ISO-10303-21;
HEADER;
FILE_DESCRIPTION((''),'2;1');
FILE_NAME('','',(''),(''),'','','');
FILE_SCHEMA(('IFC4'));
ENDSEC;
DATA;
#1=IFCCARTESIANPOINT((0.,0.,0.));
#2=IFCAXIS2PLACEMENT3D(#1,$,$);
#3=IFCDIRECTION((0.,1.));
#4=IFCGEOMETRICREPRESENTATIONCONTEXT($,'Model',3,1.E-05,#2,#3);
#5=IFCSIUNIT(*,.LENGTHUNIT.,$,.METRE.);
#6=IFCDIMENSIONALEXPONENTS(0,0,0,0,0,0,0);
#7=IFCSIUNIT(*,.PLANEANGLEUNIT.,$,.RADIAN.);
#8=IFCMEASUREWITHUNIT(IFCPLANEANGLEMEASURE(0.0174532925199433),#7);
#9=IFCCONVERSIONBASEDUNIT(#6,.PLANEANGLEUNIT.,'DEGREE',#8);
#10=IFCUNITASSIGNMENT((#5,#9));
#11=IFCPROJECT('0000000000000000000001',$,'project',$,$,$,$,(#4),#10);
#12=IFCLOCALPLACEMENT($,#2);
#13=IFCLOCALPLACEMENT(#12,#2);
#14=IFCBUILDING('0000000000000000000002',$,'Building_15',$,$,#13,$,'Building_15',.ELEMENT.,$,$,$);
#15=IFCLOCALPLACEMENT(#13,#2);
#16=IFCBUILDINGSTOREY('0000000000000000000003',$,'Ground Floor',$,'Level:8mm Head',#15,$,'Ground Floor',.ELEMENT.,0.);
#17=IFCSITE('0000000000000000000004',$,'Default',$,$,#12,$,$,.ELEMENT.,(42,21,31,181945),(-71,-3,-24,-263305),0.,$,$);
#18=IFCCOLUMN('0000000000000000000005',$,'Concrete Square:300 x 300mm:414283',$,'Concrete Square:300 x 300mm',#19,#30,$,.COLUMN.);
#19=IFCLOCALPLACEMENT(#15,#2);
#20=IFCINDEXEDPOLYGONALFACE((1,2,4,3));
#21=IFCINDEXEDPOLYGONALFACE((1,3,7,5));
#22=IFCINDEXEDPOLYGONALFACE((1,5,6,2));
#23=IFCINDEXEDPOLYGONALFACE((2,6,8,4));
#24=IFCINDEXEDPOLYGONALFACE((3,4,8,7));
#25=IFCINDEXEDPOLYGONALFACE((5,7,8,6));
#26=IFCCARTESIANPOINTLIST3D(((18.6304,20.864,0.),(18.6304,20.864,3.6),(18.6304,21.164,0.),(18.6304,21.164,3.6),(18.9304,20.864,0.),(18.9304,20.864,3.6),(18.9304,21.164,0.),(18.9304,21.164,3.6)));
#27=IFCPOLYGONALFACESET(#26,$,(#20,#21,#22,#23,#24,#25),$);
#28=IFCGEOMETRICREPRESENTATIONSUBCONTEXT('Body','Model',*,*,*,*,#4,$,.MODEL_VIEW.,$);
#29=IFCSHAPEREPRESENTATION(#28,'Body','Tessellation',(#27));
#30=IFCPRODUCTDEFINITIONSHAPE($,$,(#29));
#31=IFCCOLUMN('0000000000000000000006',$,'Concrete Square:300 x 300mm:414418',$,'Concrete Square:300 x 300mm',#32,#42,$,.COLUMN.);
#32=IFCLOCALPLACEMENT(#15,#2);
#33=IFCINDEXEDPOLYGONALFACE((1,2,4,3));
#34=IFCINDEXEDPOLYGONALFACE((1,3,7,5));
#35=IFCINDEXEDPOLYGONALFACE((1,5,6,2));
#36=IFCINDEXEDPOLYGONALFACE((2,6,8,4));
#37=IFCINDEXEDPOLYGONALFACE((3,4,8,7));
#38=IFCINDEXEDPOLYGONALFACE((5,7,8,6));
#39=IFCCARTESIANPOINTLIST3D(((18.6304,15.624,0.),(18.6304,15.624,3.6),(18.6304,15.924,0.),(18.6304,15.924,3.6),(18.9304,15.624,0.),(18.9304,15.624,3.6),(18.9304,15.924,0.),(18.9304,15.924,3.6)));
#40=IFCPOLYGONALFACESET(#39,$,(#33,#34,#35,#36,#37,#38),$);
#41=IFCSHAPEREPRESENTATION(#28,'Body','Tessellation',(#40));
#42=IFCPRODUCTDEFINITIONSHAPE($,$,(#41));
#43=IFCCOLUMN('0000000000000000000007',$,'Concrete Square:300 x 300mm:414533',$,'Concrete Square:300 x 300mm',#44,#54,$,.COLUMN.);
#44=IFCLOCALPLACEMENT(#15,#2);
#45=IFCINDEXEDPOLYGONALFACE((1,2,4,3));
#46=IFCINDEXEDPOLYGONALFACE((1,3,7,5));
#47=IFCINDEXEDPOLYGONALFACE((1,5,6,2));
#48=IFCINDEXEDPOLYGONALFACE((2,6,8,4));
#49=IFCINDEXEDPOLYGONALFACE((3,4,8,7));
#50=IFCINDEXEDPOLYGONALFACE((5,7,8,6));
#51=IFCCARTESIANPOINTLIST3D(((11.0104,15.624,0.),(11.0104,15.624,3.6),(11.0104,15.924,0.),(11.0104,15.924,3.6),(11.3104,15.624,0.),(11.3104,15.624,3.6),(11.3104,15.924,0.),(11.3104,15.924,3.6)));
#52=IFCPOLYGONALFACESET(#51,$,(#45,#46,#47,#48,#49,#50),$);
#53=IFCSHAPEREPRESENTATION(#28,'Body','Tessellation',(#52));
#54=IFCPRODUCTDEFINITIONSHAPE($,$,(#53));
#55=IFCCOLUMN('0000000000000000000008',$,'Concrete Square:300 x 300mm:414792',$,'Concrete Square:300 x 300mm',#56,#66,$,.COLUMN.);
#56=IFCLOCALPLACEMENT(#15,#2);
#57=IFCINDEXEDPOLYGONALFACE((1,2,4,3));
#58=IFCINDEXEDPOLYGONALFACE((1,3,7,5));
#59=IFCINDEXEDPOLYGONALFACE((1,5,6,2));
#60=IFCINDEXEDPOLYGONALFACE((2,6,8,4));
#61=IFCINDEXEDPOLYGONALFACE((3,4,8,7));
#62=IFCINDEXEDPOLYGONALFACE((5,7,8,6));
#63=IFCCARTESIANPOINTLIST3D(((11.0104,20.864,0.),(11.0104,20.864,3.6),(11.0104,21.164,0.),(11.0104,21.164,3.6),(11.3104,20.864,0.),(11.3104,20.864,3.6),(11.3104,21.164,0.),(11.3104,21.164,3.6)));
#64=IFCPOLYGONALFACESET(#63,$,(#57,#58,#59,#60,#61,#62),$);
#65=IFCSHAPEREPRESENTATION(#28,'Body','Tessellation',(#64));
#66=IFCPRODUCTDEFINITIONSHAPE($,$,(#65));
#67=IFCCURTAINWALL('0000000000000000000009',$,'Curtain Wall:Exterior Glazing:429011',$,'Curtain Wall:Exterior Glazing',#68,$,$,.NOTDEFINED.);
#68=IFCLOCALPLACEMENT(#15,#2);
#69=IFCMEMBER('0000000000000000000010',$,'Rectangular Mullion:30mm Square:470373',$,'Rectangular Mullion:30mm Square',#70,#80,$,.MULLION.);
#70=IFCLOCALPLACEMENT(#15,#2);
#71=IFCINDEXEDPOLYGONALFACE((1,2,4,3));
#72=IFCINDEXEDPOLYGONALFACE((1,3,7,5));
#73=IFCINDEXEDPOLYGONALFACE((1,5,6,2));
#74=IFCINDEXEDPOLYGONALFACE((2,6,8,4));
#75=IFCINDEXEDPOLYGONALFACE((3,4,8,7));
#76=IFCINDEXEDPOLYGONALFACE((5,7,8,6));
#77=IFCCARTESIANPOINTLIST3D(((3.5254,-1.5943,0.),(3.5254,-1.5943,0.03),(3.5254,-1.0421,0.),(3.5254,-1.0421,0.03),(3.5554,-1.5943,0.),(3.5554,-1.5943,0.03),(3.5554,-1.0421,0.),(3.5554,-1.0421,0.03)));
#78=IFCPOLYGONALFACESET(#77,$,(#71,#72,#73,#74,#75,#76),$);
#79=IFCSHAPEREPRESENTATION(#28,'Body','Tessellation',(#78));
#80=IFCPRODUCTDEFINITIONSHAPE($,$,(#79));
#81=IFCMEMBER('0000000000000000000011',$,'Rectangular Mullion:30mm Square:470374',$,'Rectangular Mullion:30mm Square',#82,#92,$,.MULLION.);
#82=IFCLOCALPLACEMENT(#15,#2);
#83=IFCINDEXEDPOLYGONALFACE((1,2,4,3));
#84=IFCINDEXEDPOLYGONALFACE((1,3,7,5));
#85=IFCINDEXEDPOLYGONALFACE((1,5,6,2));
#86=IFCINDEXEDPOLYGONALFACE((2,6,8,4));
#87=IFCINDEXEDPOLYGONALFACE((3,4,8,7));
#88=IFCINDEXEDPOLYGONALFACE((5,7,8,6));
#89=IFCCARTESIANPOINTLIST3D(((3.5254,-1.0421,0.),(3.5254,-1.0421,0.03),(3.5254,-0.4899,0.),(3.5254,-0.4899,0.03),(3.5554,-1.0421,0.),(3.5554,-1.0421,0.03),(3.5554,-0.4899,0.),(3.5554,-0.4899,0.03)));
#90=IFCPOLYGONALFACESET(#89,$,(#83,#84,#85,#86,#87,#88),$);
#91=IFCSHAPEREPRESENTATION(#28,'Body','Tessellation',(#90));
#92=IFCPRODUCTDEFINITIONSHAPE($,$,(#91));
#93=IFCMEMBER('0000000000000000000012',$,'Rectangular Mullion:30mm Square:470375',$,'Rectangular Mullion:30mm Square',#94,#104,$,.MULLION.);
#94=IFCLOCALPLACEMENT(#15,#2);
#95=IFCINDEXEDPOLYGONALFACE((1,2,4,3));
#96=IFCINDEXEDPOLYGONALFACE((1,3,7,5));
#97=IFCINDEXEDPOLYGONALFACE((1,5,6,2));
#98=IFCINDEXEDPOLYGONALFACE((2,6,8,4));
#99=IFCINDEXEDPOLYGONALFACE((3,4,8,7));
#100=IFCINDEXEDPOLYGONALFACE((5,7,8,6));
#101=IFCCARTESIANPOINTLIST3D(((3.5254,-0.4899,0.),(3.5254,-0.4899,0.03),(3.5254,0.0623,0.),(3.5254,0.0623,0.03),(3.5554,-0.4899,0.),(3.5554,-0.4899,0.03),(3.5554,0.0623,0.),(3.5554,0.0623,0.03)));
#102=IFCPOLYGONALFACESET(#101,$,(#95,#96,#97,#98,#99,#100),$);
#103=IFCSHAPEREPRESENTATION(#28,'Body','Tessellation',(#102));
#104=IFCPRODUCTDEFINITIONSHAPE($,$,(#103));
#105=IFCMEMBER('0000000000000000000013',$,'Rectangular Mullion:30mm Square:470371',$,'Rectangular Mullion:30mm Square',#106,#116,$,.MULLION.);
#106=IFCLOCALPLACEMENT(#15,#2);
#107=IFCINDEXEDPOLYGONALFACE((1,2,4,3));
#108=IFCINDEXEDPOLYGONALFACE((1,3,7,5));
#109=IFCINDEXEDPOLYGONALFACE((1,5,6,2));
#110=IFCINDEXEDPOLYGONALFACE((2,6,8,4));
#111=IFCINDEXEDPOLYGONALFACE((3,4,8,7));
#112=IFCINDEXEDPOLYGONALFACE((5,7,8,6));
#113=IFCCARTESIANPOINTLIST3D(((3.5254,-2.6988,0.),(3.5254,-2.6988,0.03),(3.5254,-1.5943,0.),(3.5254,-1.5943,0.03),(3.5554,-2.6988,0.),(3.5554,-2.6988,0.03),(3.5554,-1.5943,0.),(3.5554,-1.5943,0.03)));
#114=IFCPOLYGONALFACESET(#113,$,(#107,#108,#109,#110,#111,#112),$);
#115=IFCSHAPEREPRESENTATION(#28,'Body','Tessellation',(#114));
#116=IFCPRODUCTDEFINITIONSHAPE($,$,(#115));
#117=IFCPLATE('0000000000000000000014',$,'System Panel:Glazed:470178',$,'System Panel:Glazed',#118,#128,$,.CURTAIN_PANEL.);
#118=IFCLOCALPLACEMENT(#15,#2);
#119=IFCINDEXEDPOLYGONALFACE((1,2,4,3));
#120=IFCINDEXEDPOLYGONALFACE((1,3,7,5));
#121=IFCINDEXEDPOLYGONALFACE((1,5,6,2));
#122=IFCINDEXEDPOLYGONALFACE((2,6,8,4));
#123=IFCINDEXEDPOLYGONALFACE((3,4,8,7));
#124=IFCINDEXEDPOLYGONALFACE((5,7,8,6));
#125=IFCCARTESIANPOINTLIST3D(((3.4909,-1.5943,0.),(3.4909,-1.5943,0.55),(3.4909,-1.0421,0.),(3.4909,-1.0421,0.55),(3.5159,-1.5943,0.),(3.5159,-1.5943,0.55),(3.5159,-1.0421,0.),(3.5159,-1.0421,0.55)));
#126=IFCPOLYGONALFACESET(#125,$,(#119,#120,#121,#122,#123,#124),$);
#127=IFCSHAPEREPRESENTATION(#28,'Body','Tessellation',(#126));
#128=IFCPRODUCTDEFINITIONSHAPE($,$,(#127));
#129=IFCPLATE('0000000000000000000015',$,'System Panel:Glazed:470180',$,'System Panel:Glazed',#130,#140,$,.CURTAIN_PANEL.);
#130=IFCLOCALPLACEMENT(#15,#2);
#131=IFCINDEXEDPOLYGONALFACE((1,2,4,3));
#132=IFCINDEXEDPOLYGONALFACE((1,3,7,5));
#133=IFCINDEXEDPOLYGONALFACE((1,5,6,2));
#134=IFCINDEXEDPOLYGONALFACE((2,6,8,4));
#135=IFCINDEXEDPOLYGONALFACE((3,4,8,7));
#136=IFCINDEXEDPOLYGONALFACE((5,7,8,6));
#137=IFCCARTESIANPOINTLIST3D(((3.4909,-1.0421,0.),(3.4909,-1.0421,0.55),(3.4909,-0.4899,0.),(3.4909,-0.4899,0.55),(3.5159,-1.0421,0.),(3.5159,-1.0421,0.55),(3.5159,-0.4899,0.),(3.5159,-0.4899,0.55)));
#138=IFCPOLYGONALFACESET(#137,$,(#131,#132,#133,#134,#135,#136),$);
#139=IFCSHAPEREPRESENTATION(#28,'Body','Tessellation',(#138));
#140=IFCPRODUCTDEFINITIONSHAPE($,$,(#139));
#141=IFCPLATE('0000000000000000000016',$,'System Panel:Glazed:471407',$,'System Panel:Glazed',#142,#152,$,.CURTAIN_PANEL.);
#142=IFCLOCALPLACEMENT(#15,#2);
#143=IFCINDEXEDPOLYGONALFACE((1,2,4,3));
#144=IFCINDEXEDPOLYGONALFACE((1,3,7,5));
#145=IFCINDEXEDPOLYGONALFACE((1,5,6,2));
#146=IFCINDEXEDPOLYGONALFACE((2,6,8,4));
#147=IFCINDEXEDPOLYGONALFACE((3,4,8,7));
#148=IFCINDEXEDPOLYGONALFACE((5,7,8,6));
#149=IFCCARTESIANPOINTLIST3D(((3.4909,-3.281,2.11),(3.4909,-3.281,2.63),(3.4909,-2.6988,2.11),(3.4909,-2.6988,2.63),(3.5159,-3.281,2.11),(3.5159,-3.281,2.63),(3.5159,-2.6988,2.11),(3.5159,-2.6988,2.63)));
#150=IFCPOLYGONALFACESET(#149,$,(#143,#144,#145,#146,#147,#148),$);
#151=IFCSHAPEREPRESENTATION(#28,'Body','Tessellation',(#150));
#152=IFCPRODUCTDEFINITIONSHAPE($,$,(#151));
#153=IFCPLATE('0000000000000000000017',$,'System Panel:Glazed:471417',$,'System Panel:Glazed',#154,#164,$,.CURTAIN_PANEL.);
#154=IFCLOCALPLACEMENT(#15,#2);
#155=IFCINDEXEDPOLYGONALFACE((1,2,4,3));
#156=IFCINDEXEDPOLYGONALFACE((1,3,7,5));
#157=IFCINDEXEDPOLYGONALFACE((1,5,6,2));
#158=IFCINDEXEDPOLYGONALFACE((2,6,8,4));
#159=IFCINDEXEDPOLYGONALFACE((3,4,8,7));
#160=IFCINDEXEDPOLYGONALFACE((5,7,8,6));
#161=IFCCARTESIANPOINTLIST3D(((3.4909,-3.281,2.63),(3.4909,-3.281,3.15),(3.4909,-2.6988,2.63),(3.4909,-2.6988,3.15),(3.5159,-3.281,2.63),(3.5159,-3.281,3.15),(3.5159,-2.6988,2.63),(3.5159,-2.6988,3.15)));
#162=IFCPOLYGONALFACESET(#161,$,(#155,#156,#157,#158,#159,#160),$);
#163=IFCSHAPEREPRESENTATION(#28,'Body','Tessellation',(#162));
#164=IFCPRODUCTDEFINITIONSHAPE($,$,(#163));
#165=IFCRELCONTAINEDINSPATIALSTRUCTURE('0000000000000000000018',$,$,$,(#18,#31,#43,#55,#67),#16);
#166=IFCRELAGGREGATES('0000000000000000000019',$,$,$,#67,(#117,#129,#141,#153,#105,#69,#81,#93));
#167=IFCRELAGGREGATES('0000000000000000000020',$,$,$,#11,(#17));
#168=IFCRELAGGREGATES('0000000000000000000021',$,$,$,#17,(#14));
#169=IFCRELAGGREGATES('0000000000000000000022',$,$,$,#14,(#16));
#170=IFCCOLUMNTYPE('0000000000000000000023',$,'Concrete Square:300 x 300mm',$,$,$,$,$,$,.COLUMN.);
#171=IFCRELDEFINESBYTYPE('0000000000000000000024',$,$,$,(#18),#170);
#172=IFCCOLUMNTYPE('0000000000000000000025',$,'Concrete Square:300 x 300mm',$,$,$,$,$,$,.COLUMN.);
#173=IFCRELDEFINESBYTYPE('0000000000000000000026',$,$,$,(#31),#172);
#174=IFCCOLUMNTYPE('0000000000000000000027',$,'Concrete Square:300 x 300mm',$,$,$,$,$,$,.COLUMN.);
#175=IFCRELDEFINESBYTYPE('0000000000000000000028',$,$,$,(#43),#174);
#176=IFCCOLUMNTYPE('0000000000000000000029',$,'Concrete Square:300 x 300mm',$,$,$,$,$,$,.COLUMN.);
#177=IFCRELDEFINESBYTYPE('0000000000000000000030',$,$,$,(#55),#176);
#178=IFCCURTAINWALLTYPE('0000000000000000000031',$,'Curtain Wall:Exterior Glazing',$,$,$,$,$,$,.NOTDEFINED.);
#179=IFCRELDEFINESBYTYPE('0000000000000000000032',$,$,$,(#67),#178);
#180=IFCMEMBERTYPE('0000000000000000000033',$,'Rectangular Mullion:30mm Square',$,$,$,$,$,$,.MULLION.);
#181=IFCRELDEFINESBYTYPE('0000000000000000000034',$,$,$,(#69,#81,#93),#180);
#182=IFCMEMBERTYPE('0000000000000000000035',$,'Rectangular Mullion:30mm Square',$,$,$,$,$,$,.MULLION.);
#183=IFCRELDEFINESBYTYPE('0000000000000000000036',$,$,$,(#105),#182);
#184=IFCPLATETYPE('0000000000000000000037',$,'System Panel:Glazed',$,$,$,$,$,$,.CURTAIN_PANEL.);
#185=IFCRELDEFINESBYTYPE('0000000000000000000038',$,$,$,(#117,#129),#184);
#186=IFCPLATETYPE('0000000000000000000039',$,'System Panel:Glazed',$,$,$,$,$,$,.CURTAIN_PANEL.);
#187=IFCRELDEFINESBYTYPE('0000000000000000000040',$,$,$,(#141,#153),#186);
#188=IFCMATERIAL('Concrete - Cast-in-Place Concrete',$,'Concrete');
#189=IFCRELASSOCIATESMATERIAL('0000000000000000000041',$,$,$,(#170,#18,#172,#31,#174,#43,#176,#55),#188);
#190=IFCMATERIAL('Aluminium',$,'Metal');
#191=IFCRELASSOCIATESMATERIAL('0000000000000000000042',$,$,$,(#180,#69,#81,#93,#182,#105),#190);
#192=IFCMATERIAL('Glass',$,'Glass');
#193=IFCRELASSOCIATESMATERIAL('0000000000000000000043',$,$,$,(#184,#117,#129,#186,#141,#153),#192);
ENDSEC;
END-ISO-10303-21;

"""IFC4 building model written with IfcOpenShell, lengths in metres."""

from ifc_helpers import new_model, entity, si_unit, converted_unit, direction, frame, origin, place, context, subcontext, project, spatial, indexed_curve, outline, extrude, source, transform, mapped, material, type_object, type_shapes, element, aggregate, save


model = new_model("IFC4")

# Units and contexts
model_context = context("Model", 3, precision=1e-05, world=origin(), true_north=direction((0.0, 1.0)))
body_context = subcontext(model_context, "Body", "Model", "MODEL_VIEW")
ifc_project = project(units=[si_unit("LENGTHUNIT", "METRE"), converted_unit("PLANEANGLEUNIT", "DEGREE", entity("IfcPlaneAngleMeasure", 0.0174532925199433), si_unit("PLANEANGLEUNIT", "RADIAN"), dimensions=[0, 0, 0, 0, 0, 0, 0])], contexts=[model_context])

# Site, building, storey
site_placement = place(None, origin())
site = spatial("IfcSite", under=ifc_project, at=site_placement, Name="Default", CompositionType="ELEMENT", RefLatitude=(42, 21, 31, 181945), RefLongitude=(-71, -3, -24, -263305), RefElevation=0.0)
building_placement = place(site_placement, origin())
building = spatial("IfcBuilding", under=site, at=building_placement, Name="Building_15", LongName="Building_15", CompositionType="ELEMENT")
storey_placement = place(building_placement, origin())
storey = spatial("IfcBuildingStorey", under=building, at=storey_placement, Name="Ground Floor", ObjectType="Level:8mm Head", LongName="Ground Floor", CompositionType="ELEMENT", Elevation=0.0)

# Columns
ifc_material_1 = material(Name="Concrete - Cast-in-Place Concrete", Category="Concrete")
column_type_1 = type_object("IfcColumnType", Name="Concrete Square:300 x 300mm", PredefinedType="COLUMN", material=ifc_material_1)
shared_shape_1 = source(origin(), body_context, "Body", "SweptSolid", [
    extrude(outline(indexed_curve([(-0.15, -0.15), (0.15, -0.15), (0.15, 0.15), (-0.15, 0.15), (-0.15, -0.15)], self_intersect=False)), frame((18.7804, 21.014, 0.0), z_axis=(0.0, 0.0, 1.0), x_axis=(-1.0, 0.0, 0.0)), (0.0, 0.0, 1.0), 3.6),
])
type_shapes(column_type_1, [shared_shape_1])
column_1_placement = place(storey_placement, origin())
element("IfcColumn", 1, at=column_1_placement, inside=storey, type_object=column_type_1, material=ifc_material_1, Name="Concrete Square:300 x 300mm:414283", ObjectType="Concrete Square:300 x 300mm", PredefinedType="COLUMN", context=body_context, shape_type="MappedRepresentation", body=[
    mapped(shared_shape_1, transform((0.0, 0.0, 0.0), scale=1.0)),
])
column_type_2 = type_object("IfcColumnType", Name="Concrete Square:300 x 300mm", PredefinedType="COLUMN", material=ifc_material_1)
shared_shape_2 = source(origin(), body_context, "Body", "SweptSolid", [
    extrude(outline(indexed_curve([(-0.15, -0.15), (0.15, -0.15), (0.15, 0.15), (-0.15, 0.15), (-0.15, -0.15)], self_intersect=False)), frame((18.7804, 15.774, 0.0), z_axis=(0.0, 0.0, 1.0), x_axis=(-1.0, 0.0, 0.0)), (0.0, 0.0, 1.0), 3.6),
])
type_shapes(column_type_2, [shared_shape_2])
column_2_placement = place(storey_placement, origin())
element("IfcColumn", 2, at=column_2_placement, inside=storey, type_object=column_type_2, material=ifc_material_1, Name="Concrete Square:300 x 300mm:414418", ObjectType="Concrete Square:300 x 300mm", PredefinedType="COLUMN", context=body_context, shape_type="MappedRepresentation", body=[
    mapped(shared_shape_2, transform((0.0, 0.0, 0.0), scale=1.0)),
])
column_type_3 = type_object("IfcColumnType", Name="Concrete Square:300 x 300mm", PredefinedType="COLUMN", material=ifc_material_1)
shared_shape_3 = source(origin(), body_context, "Body", "SweptSolid", [
    extrude(outline(indexed_curve([(-0.15, -0.15), (0.15, -0.15), (0.15, 0.15), (-0.15, 0.15), (-0.15, -0.15)], self_intersect=False)), frame((11.1604, 15.774, 0.0), z_axis=(0.0, 0.0, 1.0), x_axis=(-1.0, 0.0, 0.0)), (0.0, 0.0, 1.0), 3.6),
])
type_shapes(column_type_3, [shared_shape_3])
column_3_placement = place(storey_placement, origin())
element("IfcColumn", 3, at=column_3_placement, inside=storey, type_object=column_type_3, material=ifc_material_1, Name="Concrete Square:300 x 300mm:414533", ObjectType="Concrete Square:300 x 300mm", PredefinedType="COLUMN", context=body_context, shape_type="MappedRepresentation", body=[
    mapped(shared_shape_3, transform((0.0, 0.0, 0.0), scale=1.0)),
])
column_type_4 = type_object("IfcColumnType", Name="Concrete Square:300 x 300mm", PredefinedType="COLUMN", material=ifc_material_1)
shared_shape_4 = source(origin(), body_context, "Body", "SweptSolid", [
    extrude(outline(indexed_curve([(-0.15, -0.15), (0.15, -0.15), (0.15, 0.15), (-0.15, 0.15), (-0.15, -0.15)], self_intersect=False)), frame((11.1604, 21.014, 0.0), z_axis=(0.0, 0.0, 1.0), x_axis=(-1.0, 0.0, 0.0)), (0.0, 0.0, 1.0), 3.6),
])
type_shapes(column_type_4, [shared_shape_4])
column_4_placement = place(storey_placement, origin())
element("IfcColumn", 4, at=column_4_placement, inside=storey, type_object=column_type_4, material=ifc_material_1, Name="Concrete Square:300 x 300mm:414792", ObjectType="Concrete Square:300 x 300mm", PredefinedType="COLUMN", context=body_context, shape_type="MappedRepresentation", body=[
    mapped(shared_shape_4, transform((0.0, 0.0, 0.0), scale=1.0)),
])

# Curtain wall, members, plates
curtain_wall_type = type_object("IfcCurtainWallType", Name="Curtain Wall:Exterior Glazing", PredefinedType="NOTDEFINED")
curtain_wall_placement = place(storey_placement, origin())
curtain_wall = element("IfcCurtainWall", 5, at=curtain_wall_placement, inside=storey, type_object=curtain_wall_type, Name="Curtain Wall:Exterior Glazing:429011", ObjectType="Curtain Wall:Exterior Glazing", PredefinedType="NOTDEFINED")
ifc_material_2 = material(Name="Aluminium", Category="Metal")
member_type_1 = type_object("IfcMemberType", Name="Rectangular Mullion:30mm Square", PredefinedType="MULLION", material=ifc_material_2)
shared_shape_5 = source(origin(), body_context, "Body", "SweptSolid", [
    extrude(outline(indexed_curve([(-0.015, -0.015), (0.015, -0.015), (0.015, 0.015), (-0.015, 0.015), (-0.015, -0.015)], self_intersect=False)), frame((-0.015, 0.0, -0.5522), z_axis=(0.0, 0.0, 1.0), x_axis=(-1.0, 0.0, 0.0)), (0.0, 0.0, 1.0), 0.5522),
])
type_shapes(member_type_1, [shared_shape_5])
member_1_placement = place(curtain_wall_placement, frame((3.5404, -1.5943, 0.0), z_axis=(0.0, -1.0, 0.0), x_axis=(0.0, 0.0, -1.0)))
member_1 = element("IfcMember", 6, at=member_1_placement, type_object=member_type_1, material=ifc_material_2, Name="Rectangular Mullion:30mm Square:470373", ObjectType="Rectangular Mullion:30mm Square", PredefinedType="MULLION", context=body_context, shape_type="MappedRepresentation", body=[
    mapped(shared_shape_5, transform((0.0, 0.0, 0.0), scale=1.0)),
])
member_2_placement = place(curtain_wall_placement, frame((3.5404, -1.0421, 0.0), z_axis=(0.0, -1.0, 0.0), x_axis=(0.0, 0.0, -1.0)))
member_2 = element("IfcMember", 7, at=member_2_placement, type_object=member_type_1, material=ifc_material_2, Name="Rectangular Mullion:30mm Square:470374", ObjectType="Rectangular Mullion:30mm Square", PredefinedType="MULLION", context=body_context, shape_type="MappedRepresentation", body=[
    mapped(shared_shape_5, transform((0.0, 0.0, 0.0), scale=1.0)),
])
member_3_placement = place(curtain_wall_placement, frame((3.5404, -0.4899, 0.0), z_axis=(0.0, -1.0, 0.0), x_axis=(0.0, 0.0, -1.0)))
member_3 = element("IfcMember", 8, at=member_3_placement, type_object=member_type_1, material=ifc_material_2, Name="Rectangular Mullion:30mm Square:470375", ObjectType="Rectangular Mullion:30mm Square", PredefinedType="MULLION", context=body_context, shape_type="MappedRepresentation", body=[
    mapped(shared_shape_5, transform((0.0, 0.0, 0.0), scale=1.0)),
])
member_type_2 = type_object("IfcMemberType", Name="Rectangular Mullion:30mm Square", PredefinedType="MULLION", material=ifc_material_2)
shared_shape_6 = source(origin(), body_context, "Body", "SweptSolid", [
    extrude(outline(indexed_curve([(-0.015, -0.015), (0.015, -0.015), (0.015, 0.015), (-0.015, 0.015), (-0.015, -0.015)], self_intersect=False)), frame((-0.015, 0.0, -1.1044), z_axis=(0.0, 0.0, 1.0), x_axis=(-1.0, 0.0, 0.0)), (0.0, 0.0, 1.0), 1.1044),
])
type_shapes(member_type_2, [shared_shape_6])
member_4_placement = place(curtain_wall_placement, frame((3.5404, -2.6988, 0.0), z_axis=(0.0, -1.0, 0.0), x_axis=(0.0, 0.0, -1.0)))
member_4 = element("IfcMember", 9, at=member_4_placement, type_object=member_type_2, material=ifc_material_2, Name="Rectangular Mullion:30mm Square:470371", ObjectType="Rectangular Mullion:30mm Square", PredefinedType="MULLION", context=body_context, shape_type="MappedRepresentation", body=[
    mapped(shared_shape_6, transform((0.0, 0.0, 0.0), scale=1.0)),
])
ifc_material_3 = material(Name="Glass", Category="Glass")
plate_type_1 = type_object("IfcPlateType", Name="System Panel:Glazed", PredefinedType="CURTAIN_PANEL", material=ifc_material_3)
shared_shape_7 = source(origin(), body_context, "Body", "SweptSolid", [
    extrude(outline(indexed_curve([(-0.0125, -0.2761), (0.0125, -0.2761), (0.0125, 0.2761), (-0.0125, 0.2761), (-0.0125, -0.2761)], self_intersect=False)), frame((0.0, 0.037, 0.0), z_axis=(0.0, 0.0, 1.0), x_axis=(0.0, 1.0, 0.0)), (0.0, 0.0, 1.0), 0.55),
])
type_shapes(plate_type_1, [shared_shape_7])
plate_1_placement = place(curtain_wall_placement, frame((3.5404, -1.3182, 0.0), z_axis=(0.0, 0.0, 1.0), x_axis=(0.0, 1.0, 0.0)))
plate_1 = element("IfcPlate", 10, at=plate_1_placement, type_object=plate_type_1, material=ifc_material_3, Name="System Panel:Glazed:470178", ObjectType="System Panel:Glazed", PredefinedType="CURTAIN_PANEL", context=body_context, shape_type="MappedRepresentation", body=[
    mapped(shared_shape_7, transform((0.0, 0.0, 0.0), scale=1.0)),
])
plate_2_placement = place(curtain_wall_placement, frame((3.5404, -0.766, 0.0), z_axis=(0.0, 0.0, 1.0), x_axis=(0.0, 1.0, 0.0)))
plate_2 = element("IfcPlate", 11, at=plate_2_placement, type_object=plate_type_1, material=ifc_material_3, Name="System Panel:Glazed:470180", ObjectType="System Panel:Glazed", PredefinedType="CURTAIN_PANEL", context=body_context, shape_type="MappedRepresentation", body=[
    mapped(shared_shape_7, transform((0.0, 0.0, 0.0), scale=1.0)),
])
plate_type_2 = type_object("IfcPlateType", Name="System Panel:Glazed", PredefinedType="CURTAIN_PANEL", material=ifc_material_3)
shared_shape_8 = source(origin(), body_context, "Body", "SweptSolid", [
    extrude(outline(indexed_curve([(-0.0125, -0.2911), (0.0125, -0.2911), (0.0125, 0.2911), (-0.0125, 0.2911), (-0.0125, -0.2911)], self_intersect=False)), frame((0.0, 0.037, 0.0), z_axis=(0.0, 0.0, 1.0), x_axis=(0.0, 1.0, 0.0)), (0.0, 0.0, 1.0), 0.52),
])
type_shapes(plate_type_2, [shared_shape_8])
plate_3_placement = place(curtain_wall_placement, frame((3.5404, -2.9899, 2.11), z_axis=(0.0, 0.0, 1.0), x_axis=(0.0, 1.0, 0.0)))
plate_3 = element("IfcPlate", 12, at=plate_3_placement, type_object=plate_type_2, material=ifc_material_3, Name="System Panel:Glazed:471407", ObjectType="System Panel:Glazed", PredefinedType="CURTAIN_PANEL", context=body_context, shape_type="MappedRepresentation", body=[
    mapped(shared_shape_8, transform((0.0, 0.0, 0.0), scale=1.0)),
])
plate_4_placement = place(curtain_wall_placement, frame((3.5404, -2.9899, 2.63), z_axis=(0.0, 0.0, 1.0), x_axis=(0.0, 1.0, 0.0)))
plate_4 = element("IfcPlate", 13, at=plate_4_placement, type_object=plate_type_2, material=ifc_material_3, Name="System Panel:Glazed:471417", ObjectType="System Panel:Glazed", PredefinedType="CURTAIN_PANEL", context=body_context, shape_type="MappedRepresentation", body=[
    mapped(shared_shape_8, transform((0.0, 0.0, 0.0), scale=1.0)),
])
aggregate(curtain_wall, [plate_1, plate_2, plate_3, plate_4, member_4, member_1, member_2, member_3])

save(model, "model.ifc")
